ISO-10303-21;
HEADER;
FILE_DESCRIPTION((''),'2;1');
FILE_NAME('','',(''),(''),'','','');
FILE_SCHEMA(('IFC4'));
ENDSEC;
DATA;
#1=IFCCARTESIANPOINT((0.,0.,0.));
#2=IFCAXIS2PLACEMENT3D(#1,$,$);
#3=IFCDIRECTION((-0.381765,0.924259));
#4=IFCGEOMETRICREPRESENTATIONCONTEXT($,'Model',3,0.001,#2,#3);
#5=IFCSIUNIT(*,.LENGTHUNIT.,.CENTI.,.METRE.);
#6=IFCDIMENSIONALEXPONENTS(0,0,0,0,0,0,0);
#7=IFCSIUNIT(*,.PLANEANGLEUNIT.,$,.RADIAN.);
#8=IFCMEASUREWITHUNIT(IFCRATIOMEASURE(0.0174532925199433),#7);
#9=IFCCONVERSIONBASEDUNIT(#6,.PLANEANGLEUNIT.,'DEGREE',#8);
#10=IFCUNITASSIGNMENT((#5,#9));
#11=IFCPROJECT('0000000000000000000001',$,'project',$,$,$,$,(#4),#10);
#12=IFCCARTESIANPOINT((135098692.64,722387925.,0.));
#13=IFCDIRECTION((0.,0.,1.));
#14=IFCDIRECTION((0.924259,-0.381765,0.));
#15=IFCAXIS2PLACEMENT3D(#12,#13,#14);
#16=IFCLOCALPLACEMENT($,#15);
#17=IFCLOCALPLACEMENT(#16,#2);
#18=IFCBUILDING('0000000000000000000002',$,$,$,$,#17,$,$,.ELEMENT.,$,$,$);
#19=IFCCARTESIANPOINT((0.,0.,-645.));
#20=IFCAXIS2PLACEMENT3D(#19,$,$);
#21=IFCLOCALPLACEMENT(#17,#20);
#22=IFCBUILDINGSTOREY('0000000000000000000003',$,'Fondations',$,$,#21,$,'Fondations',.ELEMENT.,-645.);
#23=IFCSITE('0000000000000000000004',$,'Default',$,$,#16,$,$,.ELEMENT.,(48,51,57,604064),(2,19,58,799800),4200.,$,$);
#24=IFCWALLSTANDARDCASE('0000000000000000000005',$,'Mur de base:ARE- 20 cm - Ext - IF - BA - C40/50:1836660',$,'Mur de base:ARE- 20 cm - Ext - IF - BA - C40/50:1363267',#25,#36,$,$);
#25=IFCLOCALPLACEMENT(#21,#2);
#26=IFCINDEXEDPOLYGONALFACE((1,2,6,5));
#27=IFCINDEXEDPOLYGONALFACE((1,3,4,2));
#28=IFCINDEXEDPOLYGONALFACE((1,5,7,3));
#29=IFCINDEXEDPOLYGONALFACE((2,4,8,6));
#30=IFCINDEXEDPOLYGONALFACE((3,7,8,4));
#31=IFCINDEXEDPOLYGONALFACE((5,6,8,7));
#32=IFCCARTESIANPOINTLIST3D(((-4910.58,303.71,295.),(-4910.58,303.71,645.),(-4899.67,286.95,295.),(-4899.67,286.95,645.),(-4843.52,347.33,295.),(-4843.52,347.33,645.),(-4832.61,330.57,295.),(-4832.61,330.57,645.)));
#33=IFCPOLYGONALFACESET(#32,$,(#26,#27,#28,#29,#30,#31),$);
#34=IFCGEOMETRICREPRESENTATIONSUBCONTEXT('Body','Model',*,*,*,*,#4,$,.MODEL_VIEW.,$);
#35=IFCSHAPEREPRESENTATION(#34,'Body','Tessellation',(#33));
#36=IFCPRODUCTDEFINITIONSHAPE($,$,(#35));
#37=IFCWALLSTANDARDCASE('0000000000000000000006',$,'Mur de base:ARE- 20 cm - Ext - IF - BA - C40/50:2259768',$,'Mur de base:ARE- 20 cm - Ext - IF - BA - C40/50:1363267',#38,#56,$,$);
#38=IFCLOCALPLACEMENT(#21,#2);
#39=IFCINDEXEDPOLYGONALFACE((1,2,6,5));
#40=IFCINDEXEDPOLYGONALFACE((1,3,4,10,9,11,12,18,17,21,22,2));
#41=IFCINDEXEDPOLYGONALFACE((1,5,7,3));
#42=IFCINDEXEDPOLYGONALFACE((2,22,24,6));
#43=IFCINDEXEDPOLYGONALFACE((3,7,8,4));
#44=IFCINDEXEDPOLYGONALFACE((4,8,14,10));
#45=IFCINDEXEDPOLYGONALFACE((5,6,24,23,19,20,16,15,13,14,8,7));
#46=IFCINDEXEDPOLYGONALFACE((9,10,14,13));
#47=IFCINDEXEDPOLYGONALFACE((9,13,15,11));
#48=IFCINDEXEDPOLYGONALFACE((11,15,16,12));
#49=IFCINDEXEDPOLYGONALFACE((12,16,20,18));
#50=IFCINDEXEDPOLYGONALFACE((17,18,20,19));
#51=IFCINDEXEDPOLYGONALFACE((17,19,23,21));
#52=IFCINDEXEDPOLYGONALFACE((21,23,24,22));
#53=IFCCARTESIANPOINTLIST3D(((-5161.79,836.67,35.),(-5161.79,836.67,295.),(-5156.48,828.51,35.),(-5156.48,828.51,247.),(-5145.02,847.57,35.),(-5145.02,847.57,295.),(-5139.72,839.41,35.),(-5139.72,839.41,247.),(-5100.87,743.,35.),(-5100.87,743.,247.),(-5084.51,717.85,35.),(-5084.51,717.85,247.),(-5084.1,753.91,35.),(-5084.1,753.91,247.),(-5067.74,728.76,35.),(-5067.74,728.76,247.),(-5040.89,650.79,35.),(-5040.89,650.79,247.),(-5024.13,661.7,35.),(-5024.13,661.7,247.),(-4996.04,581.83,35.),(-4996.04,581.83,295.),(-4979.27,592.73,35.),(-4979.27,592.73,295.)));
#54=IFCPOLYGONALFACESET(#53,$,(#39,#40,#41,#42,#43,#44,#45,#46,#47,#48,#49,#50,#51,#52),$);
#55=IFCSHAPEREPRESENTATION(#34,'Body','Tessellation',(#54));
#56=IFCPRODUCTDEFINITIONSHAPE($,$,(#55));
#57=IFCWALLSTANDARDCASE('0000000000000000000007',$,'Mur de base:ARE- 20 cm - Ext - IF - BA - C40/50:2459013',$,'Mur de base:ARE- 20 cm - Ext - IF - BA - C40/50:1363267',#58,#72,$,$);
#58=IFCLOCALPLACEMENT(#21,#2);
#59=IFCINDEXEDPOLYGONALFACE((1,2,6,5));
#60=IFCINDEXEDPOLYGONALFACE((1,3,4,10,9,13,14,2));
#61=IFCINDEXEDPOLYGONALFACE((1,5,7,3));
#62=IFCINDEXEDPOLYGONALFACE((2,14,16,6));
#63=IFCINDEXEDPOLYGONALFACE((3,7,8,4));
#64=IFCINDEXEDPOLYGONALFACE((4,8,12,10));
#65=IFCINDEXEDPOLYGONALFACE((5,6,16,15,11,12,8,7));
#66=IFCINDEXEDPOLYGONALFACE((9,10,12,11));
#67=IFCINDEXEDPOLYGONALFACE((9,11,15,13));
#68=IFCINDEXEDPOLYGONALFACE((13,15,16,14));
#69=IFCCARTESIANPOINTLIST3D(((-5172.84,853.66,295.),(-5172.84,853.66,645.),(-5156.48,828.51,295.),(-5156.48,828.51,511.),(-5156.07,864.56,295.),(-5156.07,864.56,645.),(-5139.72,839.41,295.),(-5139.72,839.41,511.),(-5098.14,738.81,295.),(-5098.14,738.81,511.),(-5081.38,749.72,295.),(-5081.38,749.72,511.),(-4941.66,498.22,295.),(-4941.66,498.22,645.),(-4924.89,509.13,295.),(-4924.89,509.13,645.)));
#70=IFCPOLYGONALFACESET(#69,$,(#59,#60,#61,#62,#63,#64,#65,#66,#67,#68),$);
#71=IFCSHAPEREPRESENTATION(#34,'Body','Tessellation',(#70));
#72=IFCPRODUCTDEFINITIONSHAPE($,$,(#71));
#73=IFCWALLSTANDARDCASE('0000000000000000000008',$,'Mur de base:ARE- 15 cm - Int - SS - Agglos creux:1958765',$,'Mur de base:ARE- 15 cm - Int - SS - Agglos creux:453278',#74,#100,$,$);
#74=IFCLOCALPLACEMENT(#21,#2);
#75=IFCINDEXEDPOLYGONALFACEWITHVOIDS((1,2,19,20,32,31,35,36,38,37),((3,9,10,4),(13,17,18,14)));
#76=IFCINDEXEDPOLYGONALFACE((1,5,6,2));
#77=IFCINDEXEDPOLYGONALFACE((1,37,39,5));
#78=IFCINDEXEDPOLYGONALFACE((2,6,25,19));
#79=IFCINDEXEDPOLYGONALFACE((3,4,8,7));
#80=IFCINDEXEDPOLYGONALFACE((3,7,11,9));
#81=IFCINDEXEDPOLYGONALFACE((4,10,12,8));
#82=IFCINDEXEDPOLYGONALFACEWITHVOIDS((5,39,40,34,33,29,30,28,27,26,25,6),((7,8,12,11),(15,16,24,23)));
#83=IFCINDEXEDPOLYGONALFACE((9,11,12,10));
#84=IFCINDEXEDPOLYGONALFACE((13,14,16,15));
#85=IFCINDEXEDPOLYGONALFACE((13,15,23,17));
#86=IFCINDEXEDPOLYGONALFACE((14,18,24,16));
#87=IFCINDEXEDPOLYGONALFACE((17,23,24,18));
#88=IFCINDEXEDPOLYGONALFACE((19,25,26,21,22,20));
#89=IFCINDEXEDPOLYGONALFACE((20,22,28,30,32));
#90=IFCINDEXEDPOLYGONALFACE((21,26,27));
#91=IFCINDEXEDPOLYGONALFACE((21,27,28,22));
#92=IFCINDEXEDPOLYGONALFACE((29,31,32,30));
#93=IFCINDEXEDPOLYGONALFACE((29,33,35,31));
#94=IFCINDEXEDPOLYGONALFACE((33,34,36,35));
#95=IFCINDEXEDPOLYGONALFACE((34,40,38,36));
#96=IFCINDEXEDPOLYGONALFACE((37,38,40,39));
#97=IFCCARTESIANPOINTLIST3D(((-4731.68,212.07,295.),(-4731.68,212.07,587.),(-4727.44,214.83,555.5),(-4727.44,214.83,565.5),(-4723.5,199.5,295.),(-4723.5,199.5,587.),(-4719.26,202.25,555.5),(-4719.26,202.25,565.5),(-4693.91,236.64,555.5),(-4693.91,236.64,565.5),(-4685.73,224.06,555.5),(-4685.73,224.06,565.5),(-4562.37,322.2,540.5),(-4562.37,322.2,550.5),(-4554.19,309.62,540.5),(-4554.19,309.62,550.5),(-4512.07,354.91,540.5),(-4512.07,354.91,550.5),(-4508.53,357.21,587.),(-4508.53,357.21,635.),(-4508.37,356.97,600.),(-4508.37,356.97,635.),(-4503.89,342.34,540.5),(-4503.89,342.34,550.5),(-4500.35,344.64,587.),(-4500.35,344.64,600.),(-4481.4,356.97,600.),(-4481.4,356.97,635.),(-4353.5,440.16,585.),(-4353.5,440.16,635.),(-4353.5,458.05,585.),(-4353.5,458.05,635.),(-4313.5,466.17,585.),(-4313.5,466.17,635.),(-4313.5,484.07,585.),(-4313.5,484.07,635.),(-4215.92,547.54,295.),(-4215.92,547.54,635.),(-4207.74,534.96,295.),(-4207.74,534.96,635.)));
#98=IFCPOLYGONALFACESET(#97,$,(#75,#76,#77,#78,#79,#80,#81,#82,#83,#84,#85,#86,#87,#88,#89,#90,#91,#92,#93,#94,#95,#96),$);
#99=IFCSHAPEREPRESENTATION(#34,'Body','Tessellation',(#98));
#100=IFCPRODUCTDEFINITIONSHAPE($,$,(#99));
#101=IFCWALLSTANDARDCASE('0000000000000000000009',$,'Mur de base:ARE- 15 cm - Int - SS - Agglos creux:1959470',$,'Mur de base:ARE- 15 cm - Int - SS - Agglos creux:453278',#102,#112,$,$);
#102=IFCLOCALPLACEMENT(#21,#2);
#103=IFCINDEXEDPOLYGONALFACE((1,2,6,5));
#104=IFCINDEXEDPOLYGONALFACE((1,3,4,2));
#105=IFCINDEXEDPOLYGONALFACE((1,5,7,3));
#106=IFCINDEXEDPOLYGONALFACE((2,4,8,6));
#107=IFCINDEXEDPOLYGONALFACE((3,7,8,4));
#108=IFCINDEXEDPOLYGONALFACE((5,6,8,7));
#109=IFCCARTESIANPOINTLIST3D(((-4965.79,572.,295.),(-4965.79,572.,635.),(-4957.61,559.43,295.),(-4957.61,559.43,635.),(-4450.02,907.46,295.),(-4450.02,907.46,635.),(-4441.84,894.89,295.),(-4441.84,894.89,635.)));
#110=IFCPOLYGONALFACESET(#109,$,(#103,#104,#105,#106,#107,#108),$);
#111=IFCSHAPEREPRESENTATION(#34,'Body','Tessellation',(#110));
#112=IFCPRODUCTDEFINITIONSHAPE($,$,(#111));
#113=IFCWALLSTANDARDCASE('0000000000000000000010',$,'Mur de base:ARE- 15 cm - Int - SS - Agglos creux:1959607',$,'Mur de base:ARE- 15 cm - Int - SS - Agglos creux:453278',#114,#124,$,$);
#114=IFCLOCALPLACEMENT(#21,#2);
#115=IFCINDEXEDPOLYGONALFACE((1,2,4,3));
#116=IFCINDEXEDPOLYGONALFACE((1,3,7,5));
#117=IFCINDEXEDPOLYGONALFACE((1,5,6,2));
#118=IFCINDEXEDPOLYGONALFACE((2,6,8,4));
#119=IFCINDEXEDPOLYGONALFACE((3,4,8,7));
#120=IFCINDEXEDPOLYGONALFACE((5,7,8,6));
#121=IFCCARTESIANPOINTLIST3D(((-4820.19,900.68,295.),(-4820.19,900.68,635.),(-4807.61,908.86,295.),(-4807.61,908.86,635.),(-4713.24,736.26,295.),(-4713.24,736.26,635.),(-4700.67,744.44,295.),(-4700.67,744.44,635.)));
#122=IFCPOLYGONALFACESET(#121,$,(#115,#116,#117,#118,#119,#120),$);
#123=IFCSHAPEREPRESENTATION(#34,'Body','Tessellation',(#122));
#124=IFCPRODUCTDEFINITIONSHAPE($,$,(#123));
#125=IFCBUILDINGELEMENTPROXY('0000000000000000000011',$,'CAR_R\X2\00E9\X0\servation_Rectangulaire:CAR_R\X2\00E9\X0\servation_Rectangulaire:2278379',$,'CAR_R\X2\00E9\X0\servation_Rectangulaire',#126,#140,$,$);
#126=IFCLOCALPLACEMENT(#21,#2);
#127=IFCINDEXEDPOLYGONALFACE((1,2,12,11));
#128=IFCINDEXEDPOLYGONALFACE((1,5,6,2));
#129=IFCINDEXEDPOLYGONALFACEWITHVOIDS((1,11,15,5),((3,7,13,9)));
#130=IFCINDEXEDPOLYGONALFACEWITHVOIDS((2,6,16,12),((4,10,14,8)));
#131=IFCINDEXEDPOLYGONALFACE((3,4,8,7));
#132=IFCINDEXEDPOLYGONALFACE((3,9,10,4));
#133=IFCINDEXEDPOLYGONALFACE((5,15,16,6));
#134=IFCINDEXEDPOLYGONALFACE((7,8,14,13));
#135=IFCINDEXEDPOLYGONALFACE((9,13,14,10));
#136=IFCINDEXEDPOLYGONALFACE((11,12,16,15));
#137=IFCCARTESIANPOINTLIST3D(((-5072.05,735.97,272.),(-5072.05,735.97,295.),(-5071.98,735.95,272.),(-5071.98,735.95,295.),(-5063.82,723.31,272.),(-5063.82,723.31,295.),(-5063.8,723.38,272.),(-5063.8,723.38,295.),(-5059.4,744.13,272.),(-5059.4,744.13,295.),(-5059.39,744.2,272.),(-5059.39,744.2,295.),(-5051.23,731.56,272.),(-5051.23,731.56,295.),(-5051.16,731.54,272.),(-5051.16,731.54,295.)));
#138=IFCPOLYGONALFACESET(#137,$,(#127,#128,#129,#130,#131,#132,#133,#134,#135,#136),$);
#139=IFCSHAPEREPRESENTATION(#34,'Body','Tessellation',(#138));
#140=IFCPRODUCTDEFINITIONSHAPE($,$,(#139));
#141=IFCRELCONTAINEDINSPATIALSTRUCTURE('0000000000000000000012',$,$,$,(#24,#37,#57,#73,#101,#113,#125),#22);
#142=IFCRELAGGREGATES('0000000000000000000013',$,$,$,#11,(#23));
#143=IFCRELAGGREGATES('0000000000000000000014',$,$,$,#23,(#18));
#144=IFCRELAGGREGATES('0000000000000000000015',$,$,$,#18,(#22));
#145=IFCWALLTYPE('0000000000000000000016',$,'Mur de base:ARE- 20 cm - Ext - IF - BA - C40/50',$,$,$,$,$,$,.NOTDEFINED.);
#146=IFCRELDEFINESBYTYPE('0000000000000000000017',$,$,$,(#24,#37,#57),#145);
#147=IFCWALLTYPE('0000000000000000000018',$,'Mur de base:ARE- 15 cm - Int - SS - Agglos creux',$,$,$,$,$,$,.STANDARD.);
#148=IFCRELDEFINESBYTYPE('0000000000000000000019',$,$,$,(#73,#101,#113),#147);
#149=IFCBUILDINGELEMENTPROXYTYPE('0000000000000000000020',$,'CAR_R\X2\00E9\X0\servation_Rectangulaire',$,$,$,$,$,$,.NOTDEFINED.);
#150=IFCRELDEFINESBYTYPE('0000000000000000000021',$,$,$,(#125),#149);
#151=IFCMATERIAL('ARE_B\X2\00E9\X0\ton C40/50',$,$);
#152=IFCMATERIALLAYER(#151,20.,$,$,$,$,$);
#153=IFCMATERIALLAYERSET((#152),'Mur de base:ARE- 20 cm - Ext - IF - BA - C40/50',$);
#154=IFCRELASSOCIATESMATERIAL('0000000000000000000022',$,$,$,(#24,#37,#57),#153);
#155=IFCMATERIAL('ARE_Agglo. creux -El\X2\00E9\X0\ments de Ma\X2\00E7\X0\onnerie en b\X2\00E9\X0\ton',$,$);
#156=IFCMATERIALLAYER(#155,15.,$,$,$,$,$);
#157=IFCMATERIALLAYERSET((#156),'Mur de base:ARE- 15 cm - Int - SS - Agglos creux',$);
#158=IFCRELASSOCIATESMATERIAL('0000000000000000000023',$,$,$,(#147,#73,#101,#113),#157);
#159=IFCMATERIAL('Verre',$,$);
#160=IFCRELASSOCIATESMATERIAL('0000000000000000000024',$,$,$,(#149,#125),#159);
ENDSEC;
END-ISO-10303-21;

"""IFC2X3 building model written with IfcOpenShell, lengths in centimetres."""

from ifc_helpers import new_model, entity, si_unit, converted_unit, direction, frame, frame_2d, origin, place, context, subcontext, project, spatial, polyline, rectangle, outline, extrude, clip, bounded_halfspace, source, transform, mapped, material, layer, layer_set, layer_usage, type_object, type_shapes, element, save


model = new_model("IFC2X3")

# Units and contexts
model_context = context("Model", 3, precision=0.001, world=origin(), true_north=direction((-0.381765, 0.924259)))
body_context = subcontext(model_context, "Body", "Model", "MODEL_VIEW")
ifc_project = project(units=[si_unit("LENGTHUNIT", "METRE", prefix="CENTI"), converted_unit("PLANEANGLEUNIT", "DEGREE", entity("IfcRatioMeasure", 0.0174532925199433), si_unit("PLANEANGLEUNIT", "RADIAN"), dimensions=[0, 0, 0, 0, 0, 0, 0])], contexts=[model_context])

# Site, building, storey
site_placement = place(None, frame((135098692.64, 722387925.0, 0.0), z_axis=(0.0, 0.0, 1.0), x_axis=(0.924259, -0.381765, 0.0)))
site = spatial("IfcSite", under=ifc_project, at=site_placement, Name="Default", CompositionType="ELEMENT", RefLatitude=(48, 51, 57, 604064), RefLongitude=(2, 19, 58, 799800), RefElevation=4200.0)
building_placement = place(site_placement, origin())
building = spatial("IfcBuilding", under=site, at=building_placement, CompositionType="ELEMENT")
storey_placement = place(building_placement, frame((0.0, 0.0, -645.0)))
storey = spatial("IfcBuildingStorey", under=building, at=storey_placement, Name="Fondations", LongName="Fondations", CompositionType="ELEMENT", Elevation=-645.0)

# Wall
ifc_material_1 = material(Name="ARE_Béton C40/50")
ifc_layer_1 = layer(ifc_material_1, 20.0)
ifc_layer_set_1 = layer_set([ifc_layer_1], Name="Mur de base:ARE- 20 cm - Ext - IF - BA - C40/50")
wall_type_1 = type_object("IfcWallType", Name="Mur de base:ARE- 20 cm - Ext - IF - BA - C40/50", PredefinedType="NOTDEFINED")
ifc_layer_usage_1 = layer_usage(ifc_layer_set_1, "AXIS2", "NEGATIVE", 10.0)
wall_1_placement = place(storey_placement, frame((-4838.06, 338.95, 295.0), z_axis=(0.0, 0.0, 1.0), x_axis=(-0.838282, -0.545236, 0.0)))
element("IfcWallStandardCase", 1, at=wall_1_placement, inside=storey, type_object=wall_type_1, material=ifc_layer_usage_1, Name="Mur de base:ARE- 20 cm - Ext - IF - BA - C40/50:1836660", ObjectType="Mur de base:ARE- 20 cm - Ext - IF - BA - C40/50:1363267", context=body_context, shape_type="SweptSolid", body=[
    extrude(rectangle(XDim=80.0, YDim=20.0, at=frame_2d((40.0, 0.0), x_axis=(-1.0, 0.0))), origin(), (0.0, 0.0, 1.0), 350.0),
])

# Wall, openings
ifc_layer_usage_2 = layer_usage(ifc_layer_set_1, "AXIS2", "NEGATIVE", 10.0)
wall_2_placement = place(storey_placement, frame((-4987.65, 587.28, 35.0), z_axis=(0.0, 0.0, 1.0), x_axis=(-0.545236, 0.838282, 0.0)))
wall_2 = element("IfcWallStandardCase", 2, at=wall_2_placement, inside=storey, type_object=wall_type_1, material=ifc_layer_usage_2, Name="Mur de base:ARE- 20 cm - Ext - IF - BA - C40/50:2259768", ObjectType="Mur de base:ARE- 20 cm - Ext - IF - BA - C40/50:1363267", context=body_context, shape_type="SweptSolid", body=[
    extrude(rectangle(XDim=304.0, YDim=20.0, at=frame_2d((152.0, 0.0), x_axis=(-1.0, 0.0))), origin(), (0.0, 0.0, 1.0), 260.0),
])
opening_1_placement = place(wall_2_placement, origin())
element("IfcOpeningElement", 3, at=opening_1_placement, cuts=wall_2, ObjectType="Opening", context=body_context, shape_type="SweptSolid", body=[
    extrude(rectangle(XDim=212.0, YDim=80.0, at=frame_2d((0.0, 0.0), x_axis=(0.0, 1.0))), frame((122.27, -10.0, 106.0), z_axis=(0.0, 1.0, 0.0), x_axis=(1.0, 0.0, 0.0)), (0.0, 0.0, 1.0), 20.0),
])
opening_2_placement = place(wall_2_placement, frame((-3211.76, -3860.85, -35.0), z_axis=(0.0, 0.0, 1.0), x_axis=(-0.545236, -0.838282, 0.0)))
element("IfcOpeningElement", 4, at=opening_2_placement, cuts=wall_2, ObjectType="Opening", context=body_context, shape_type="SweptSolid", body=[
    extrude(rectangle(XDim=212.0, YDim=102.0, at=frame_2d((0.0, 0.0), x_axis=(1.0, 0.0))), frame((-5000.92, 868.85, 141.0), z_axis=(-0.838282, -0.545236, 0.0), x_axis=(0.0, 0.0, -1.0)), (0.0, 0.0, 1.0), 304.8),
])

# Wall, opening
ifc_layer_usage_3 = layer_usage(ifc_layer_set_1, "AXIS2", "NEGATIVE", 10.0)
wall_3_placement = place(storey_placement, frame((-4933.28, 503.68, 295.0), z_axis=(0.0, 0.0, 1.0), x_axis=(-0.545236, 0.838282, 0.0)))
wall_3 = element("IfcWallStandardCase", 5, at=wall_3_placement, inside=storey, type_object=wall_type_1, material=ifc_layer_usage_3, Name="Mur de base:ARE- 20 cm - Ext - IF - BA - C40/50:2459013", ObjectType="Mur de base:ARE- 20 cm - Ext - IF - BA - C40/50:1363267", context=body_context, shape_type="SweptSolid", body=[
    extrude(rectangle(XDim=424.0, YDim=20.0, at=frame_2d((212.0, 0.0), x_axis=(-1.0, 0.0))), origin(), (0.0, 0.0, 1.0), 350.0),
])
opening_3_placement = place(wall_3_placement, frame((-3112.02, -3860.85, -295.0), z_axis=(0.0, 0.0, 1.0), x_axis=(-0.545236, -0.838282, 0.0)))
element("IfcOpeningElement", 6, at=opening_3_placement, cuts=wall_3, ObjectType="Opening", context=body_context, shape_type="SweptSolid", body=[
    extrude(rectangle(XDim=216.0, YDim=107.0, at=frame_2d((0.0, 0.0), x_axis=(0.0, 1.0))), frame((-4982.79, 877.66, 403.0), z_axis=(-0.838282, -0.545236, 0.0), x_axis=(-0.545236, 0.838282, 0.0)), (0.0, 0.0, 1.0), 304.8),
])

# Wall, openings
ifc_material_2 = material(Name="ARE_Agglo. creux -Eléments de Maçonnerie en béton")
ifc_layer_2 = layer(ifc_material_2, 15.0)
ifc_layer_set_2 = layer_set([ifc_layer_2], Name="Mur de base:ARE- 15 cm - Int - SS - Agglos creux")
ifc_layer_usage_4 = layer_usage(ifc_layer_set_2, "AXIS2", "POSITIVE", -7.5)
wall_type_2 = type_object("IfcWallType", Name="Mur de base:ARE- 15 cm - Int - SS - Agglos creux", PredefinedType="STANDARD", material=ifc_layer_set_2)
wall_4_placement = place(storey_placement, frame((-4727.59, 205.79, 295.0), z_axis=(0.0, 0.0, 1.0), x_axis=(0.838282, 0.545236, 0.0)))
wall_4 = element("IfcWallStandardCase", 7, at=wall_4_placement, inside=storey, type_object=wall_type_2, material=ifc_layer_usage_4, Name="Mur de base:ARE- 15 cm - Int - SS - Agglos creux:1958765", ObjectType="Mur de base:ARE- 15 cm - Int - SS - Agglos creux:453278", context=body_context, shape_type="Clipping", body=[
    clip(clip(clip(extrude(rectangle(XDim=615.26, YDim=15.0, at=frame_2d((307.63, 0.0), x_axis=(-1.0, 0.0))), origin(), (0.0, 0.0, 1.0), 340.0), bounded_halfspace(frame((451.14, 7.5, 290.0), z_axis=(0.0, 0.0, 1.0), x_axis=(0.838282, -0.545236, 0.0)), False, frame((451.14, 7.5, 290.0), z_axis=(0.0, 0.0, 1.0), x_axis=(0.838282, -0.545236, 0.0)), polyline([(0.0, 0.0), (0.0, -17.89), (40.0, 8.12), (40.0, 26.02), (0.0, 0.0)]))), bounded_halfspace(frame((288.81, -7.5, 305.0), z_axis=(0.0, 0.0, -1.0), x_axis=(-0.838282, 0.545236, 0.0)), True, frame((288.81, -7.5, 305.0), z_axis=(0.0, 0.0, -1.0), x_axis=(-0.838282, 0.545236, 0.0)), polyline([(0.0, 0.0), (18.95, -12.33), (26.97, 0.0), (0.0, 0.0)]))), bounded_halfspace(frame((266.2, 7.21, 305.0), z_axis=(0.545236, 0.838282, 0.0), x_axis=(-0.838282, 0.545236, 0.0)), True, frame((266.2, 7.21, 305.0), z_axis=(0.545236, 0.838282, 0.0), x_axis=(-0.838282, 0.545236, 0.0)), polyline([(0.0, 0.0), (0.0, 35.0), (-26.97, 35.0), (-26.97, 0.0), (0.0, 0.0)]))),
])
opening_4_placement = place(wall_4_placement, origin())
element("IfcOpeningElement", 8, at=opening_4_placement, cuts=wall_4, ObjectType="Opening", context=body_context, shape_type="SweptSolid", body=[
    extrude(rectangle(XDim=10.0, YDim=40.0, at=frame_2d((0.0, 0.0), x_axis=(1.0, 0.0))), frame((25.06, -7.5, 265.5), z_axis=(0.0, 1.0, 0.0), x_axis=(0.0, 0.0, -1.0)), (0.0, 0.0, 1.0), 15.0),
])
opening_5_placement = place(wall_4_placement, origin())
element("IfcOpeningElement", 9, at=opening_5_placement, cuts=wall_4, ObjectType="Opening", context=body_context, shape_type="SweptSolid", body=[
    extrude(rectangle(XDim=10.0, YDim=60.0, at=frame_2d((0.0, 0.0), x_axis=(1.0, 0.0))), frame((231.97, -7.5, 250.5), z_axis=(0.0, 1.0, 0.0), x_axis=(0.0, 0.0, -1.0)), (0.0, 0.0, 1.0), 15.0),
])
opening_6_placement = place(wall_4_placement, origin())
element("IfcOpeningElement", 10, at=opening_6_placement, cuts=wall_4, ObjectType="Opening", context=body_context, shape_type="SweptSolid", body=[
    extrude(rectangle(XDim=48.0, YDim=276.2, at=frame_2d((0.0, 0.0), x_axis=(0.0, 1.0))), frame((128.1, 7.5, 316.0), z_axis=(0.0, -1.0, 0.0), x_axis=(-1.0, 0.0, 0.0)), (0.0, 0.0, 1.0), 15.0),
])

# Walls
ifc_layer_usage_5 = layer_usage(ifc_layer_set_2, "AXIS2", "NEGATIVE", 7.5)
wall_5_placement = place(storey_placement, frame((-4961.7, 565.71, 295.0), z_axis=(0.0, 0.0, 1.0), x_axis=(0.838282, 0.545237, 0.0)))
element("IfcWallStandardCase", 11, at=wall_5_placement, inside=storey, type_object=wall_type_2, material=ifc_layer_usage_5, Name="Mur de base:ARE- 15 cm - Int - SS - Agglos creux:1959470", ObjectType="Mur de base:ARE- 15 cm - Int - SS - Agglos creux:453278", context=body_context, shape_type="SweptSolid", body=[
    extrude(rectangle(XDim=615.26, YDim=15.0, at=frame_2d((307.63, 0.0), x_axis=(-1.0, 0.0))), origin(), (0.0, 0.0, 1.0), 340.0),
])
ifc_layer_usage_6 = layer_usage(ifc_layer_set_2, "AXIS2", "NEGATIVE", 7.5)
wall_6_placement = place(storey_placement, frame((-4706.96, 740.35, 295.0), z_axis=(0.0, 0.0, 1.0), x_axis=(-0.545236, 0.838282, 0.0)))
element("IfcWallStandardCase", 12, at=wall_6_placement, inside=storey, type_object=wall_type_2, material=ifc_layer_usage_6, Name="Mur de base:ARE- 15 cm - Int - SS - Agglos creux:1959607", ObjectType="Mur de base:ARE- 15 cm - Int - SS - Agglos creux:453278", context=body_context, shape_type="SweptSolid", body=[
    extrude(rectangle(XDim=196.14, YDim=15.0, at=frame_2d((98.07, 0.0), x_axis=(-1.0, 0.0))), origin(), (0.0, 0.0, 1.0), 340.0),
])

# Building element proxy
ifc_material_3 = material(Name="Verre")
building_element_proxy_type_1 = type_object("IfcBuildingElementProxyType", Name="CAR_Réservation_Rectangulaire", PredefinedType="NOTDEFINED", material=ifc_material_3)
shared_shape_1 = source(origin(), body_context, "Body", "SweptSolid", [
    extrude(outline(polyline([(-7.55, -7.55), (7.55, -7.55), (7.55, 7.55), (-7.55, 7.55), (-7.55, -7.55)]), holes=[polyline([(7.5, -7.5), (-7.5, -7.5), (-7.5, 7.5), (7.5, 7.5), (7.5, -7.5)])]), frame((0.0, 0.0, -23.0), z_axis=(0.0, 0.0, 1.0), x_axis=(-1.0, 0.0, 0.0)), (0.0, 0.0, 1.0), 23.0),
])
type_shapes(building_element_proxy_type_1, [shared_shape_1])
proxy_1_placement = place(storey_placement, frame((-5061.6, 733.76, 295.0), z_axis=(0.0, 0.0, 1.0), x_axis=(0.838282, 0.545236, 0.0)))
element("IfcBuildingElementProxy", 13, at=proxy_1_placement, inside=storey, type_object=building_element_proxy_type_1, material=ifc_material_3, Name="CAR_Réservation_Rectangulaire:CAR_Réservation_Rectangulaire:2278379", ObjectType="CAR_Réservation_Rectangulaire", context=body_context, shape_type="MappedRepresentation", body=[
    mapped(shared_shape_1, transform((0.0, 0.0, 0.0), scale=1.0)),
])

save(model, "model.ifc")
